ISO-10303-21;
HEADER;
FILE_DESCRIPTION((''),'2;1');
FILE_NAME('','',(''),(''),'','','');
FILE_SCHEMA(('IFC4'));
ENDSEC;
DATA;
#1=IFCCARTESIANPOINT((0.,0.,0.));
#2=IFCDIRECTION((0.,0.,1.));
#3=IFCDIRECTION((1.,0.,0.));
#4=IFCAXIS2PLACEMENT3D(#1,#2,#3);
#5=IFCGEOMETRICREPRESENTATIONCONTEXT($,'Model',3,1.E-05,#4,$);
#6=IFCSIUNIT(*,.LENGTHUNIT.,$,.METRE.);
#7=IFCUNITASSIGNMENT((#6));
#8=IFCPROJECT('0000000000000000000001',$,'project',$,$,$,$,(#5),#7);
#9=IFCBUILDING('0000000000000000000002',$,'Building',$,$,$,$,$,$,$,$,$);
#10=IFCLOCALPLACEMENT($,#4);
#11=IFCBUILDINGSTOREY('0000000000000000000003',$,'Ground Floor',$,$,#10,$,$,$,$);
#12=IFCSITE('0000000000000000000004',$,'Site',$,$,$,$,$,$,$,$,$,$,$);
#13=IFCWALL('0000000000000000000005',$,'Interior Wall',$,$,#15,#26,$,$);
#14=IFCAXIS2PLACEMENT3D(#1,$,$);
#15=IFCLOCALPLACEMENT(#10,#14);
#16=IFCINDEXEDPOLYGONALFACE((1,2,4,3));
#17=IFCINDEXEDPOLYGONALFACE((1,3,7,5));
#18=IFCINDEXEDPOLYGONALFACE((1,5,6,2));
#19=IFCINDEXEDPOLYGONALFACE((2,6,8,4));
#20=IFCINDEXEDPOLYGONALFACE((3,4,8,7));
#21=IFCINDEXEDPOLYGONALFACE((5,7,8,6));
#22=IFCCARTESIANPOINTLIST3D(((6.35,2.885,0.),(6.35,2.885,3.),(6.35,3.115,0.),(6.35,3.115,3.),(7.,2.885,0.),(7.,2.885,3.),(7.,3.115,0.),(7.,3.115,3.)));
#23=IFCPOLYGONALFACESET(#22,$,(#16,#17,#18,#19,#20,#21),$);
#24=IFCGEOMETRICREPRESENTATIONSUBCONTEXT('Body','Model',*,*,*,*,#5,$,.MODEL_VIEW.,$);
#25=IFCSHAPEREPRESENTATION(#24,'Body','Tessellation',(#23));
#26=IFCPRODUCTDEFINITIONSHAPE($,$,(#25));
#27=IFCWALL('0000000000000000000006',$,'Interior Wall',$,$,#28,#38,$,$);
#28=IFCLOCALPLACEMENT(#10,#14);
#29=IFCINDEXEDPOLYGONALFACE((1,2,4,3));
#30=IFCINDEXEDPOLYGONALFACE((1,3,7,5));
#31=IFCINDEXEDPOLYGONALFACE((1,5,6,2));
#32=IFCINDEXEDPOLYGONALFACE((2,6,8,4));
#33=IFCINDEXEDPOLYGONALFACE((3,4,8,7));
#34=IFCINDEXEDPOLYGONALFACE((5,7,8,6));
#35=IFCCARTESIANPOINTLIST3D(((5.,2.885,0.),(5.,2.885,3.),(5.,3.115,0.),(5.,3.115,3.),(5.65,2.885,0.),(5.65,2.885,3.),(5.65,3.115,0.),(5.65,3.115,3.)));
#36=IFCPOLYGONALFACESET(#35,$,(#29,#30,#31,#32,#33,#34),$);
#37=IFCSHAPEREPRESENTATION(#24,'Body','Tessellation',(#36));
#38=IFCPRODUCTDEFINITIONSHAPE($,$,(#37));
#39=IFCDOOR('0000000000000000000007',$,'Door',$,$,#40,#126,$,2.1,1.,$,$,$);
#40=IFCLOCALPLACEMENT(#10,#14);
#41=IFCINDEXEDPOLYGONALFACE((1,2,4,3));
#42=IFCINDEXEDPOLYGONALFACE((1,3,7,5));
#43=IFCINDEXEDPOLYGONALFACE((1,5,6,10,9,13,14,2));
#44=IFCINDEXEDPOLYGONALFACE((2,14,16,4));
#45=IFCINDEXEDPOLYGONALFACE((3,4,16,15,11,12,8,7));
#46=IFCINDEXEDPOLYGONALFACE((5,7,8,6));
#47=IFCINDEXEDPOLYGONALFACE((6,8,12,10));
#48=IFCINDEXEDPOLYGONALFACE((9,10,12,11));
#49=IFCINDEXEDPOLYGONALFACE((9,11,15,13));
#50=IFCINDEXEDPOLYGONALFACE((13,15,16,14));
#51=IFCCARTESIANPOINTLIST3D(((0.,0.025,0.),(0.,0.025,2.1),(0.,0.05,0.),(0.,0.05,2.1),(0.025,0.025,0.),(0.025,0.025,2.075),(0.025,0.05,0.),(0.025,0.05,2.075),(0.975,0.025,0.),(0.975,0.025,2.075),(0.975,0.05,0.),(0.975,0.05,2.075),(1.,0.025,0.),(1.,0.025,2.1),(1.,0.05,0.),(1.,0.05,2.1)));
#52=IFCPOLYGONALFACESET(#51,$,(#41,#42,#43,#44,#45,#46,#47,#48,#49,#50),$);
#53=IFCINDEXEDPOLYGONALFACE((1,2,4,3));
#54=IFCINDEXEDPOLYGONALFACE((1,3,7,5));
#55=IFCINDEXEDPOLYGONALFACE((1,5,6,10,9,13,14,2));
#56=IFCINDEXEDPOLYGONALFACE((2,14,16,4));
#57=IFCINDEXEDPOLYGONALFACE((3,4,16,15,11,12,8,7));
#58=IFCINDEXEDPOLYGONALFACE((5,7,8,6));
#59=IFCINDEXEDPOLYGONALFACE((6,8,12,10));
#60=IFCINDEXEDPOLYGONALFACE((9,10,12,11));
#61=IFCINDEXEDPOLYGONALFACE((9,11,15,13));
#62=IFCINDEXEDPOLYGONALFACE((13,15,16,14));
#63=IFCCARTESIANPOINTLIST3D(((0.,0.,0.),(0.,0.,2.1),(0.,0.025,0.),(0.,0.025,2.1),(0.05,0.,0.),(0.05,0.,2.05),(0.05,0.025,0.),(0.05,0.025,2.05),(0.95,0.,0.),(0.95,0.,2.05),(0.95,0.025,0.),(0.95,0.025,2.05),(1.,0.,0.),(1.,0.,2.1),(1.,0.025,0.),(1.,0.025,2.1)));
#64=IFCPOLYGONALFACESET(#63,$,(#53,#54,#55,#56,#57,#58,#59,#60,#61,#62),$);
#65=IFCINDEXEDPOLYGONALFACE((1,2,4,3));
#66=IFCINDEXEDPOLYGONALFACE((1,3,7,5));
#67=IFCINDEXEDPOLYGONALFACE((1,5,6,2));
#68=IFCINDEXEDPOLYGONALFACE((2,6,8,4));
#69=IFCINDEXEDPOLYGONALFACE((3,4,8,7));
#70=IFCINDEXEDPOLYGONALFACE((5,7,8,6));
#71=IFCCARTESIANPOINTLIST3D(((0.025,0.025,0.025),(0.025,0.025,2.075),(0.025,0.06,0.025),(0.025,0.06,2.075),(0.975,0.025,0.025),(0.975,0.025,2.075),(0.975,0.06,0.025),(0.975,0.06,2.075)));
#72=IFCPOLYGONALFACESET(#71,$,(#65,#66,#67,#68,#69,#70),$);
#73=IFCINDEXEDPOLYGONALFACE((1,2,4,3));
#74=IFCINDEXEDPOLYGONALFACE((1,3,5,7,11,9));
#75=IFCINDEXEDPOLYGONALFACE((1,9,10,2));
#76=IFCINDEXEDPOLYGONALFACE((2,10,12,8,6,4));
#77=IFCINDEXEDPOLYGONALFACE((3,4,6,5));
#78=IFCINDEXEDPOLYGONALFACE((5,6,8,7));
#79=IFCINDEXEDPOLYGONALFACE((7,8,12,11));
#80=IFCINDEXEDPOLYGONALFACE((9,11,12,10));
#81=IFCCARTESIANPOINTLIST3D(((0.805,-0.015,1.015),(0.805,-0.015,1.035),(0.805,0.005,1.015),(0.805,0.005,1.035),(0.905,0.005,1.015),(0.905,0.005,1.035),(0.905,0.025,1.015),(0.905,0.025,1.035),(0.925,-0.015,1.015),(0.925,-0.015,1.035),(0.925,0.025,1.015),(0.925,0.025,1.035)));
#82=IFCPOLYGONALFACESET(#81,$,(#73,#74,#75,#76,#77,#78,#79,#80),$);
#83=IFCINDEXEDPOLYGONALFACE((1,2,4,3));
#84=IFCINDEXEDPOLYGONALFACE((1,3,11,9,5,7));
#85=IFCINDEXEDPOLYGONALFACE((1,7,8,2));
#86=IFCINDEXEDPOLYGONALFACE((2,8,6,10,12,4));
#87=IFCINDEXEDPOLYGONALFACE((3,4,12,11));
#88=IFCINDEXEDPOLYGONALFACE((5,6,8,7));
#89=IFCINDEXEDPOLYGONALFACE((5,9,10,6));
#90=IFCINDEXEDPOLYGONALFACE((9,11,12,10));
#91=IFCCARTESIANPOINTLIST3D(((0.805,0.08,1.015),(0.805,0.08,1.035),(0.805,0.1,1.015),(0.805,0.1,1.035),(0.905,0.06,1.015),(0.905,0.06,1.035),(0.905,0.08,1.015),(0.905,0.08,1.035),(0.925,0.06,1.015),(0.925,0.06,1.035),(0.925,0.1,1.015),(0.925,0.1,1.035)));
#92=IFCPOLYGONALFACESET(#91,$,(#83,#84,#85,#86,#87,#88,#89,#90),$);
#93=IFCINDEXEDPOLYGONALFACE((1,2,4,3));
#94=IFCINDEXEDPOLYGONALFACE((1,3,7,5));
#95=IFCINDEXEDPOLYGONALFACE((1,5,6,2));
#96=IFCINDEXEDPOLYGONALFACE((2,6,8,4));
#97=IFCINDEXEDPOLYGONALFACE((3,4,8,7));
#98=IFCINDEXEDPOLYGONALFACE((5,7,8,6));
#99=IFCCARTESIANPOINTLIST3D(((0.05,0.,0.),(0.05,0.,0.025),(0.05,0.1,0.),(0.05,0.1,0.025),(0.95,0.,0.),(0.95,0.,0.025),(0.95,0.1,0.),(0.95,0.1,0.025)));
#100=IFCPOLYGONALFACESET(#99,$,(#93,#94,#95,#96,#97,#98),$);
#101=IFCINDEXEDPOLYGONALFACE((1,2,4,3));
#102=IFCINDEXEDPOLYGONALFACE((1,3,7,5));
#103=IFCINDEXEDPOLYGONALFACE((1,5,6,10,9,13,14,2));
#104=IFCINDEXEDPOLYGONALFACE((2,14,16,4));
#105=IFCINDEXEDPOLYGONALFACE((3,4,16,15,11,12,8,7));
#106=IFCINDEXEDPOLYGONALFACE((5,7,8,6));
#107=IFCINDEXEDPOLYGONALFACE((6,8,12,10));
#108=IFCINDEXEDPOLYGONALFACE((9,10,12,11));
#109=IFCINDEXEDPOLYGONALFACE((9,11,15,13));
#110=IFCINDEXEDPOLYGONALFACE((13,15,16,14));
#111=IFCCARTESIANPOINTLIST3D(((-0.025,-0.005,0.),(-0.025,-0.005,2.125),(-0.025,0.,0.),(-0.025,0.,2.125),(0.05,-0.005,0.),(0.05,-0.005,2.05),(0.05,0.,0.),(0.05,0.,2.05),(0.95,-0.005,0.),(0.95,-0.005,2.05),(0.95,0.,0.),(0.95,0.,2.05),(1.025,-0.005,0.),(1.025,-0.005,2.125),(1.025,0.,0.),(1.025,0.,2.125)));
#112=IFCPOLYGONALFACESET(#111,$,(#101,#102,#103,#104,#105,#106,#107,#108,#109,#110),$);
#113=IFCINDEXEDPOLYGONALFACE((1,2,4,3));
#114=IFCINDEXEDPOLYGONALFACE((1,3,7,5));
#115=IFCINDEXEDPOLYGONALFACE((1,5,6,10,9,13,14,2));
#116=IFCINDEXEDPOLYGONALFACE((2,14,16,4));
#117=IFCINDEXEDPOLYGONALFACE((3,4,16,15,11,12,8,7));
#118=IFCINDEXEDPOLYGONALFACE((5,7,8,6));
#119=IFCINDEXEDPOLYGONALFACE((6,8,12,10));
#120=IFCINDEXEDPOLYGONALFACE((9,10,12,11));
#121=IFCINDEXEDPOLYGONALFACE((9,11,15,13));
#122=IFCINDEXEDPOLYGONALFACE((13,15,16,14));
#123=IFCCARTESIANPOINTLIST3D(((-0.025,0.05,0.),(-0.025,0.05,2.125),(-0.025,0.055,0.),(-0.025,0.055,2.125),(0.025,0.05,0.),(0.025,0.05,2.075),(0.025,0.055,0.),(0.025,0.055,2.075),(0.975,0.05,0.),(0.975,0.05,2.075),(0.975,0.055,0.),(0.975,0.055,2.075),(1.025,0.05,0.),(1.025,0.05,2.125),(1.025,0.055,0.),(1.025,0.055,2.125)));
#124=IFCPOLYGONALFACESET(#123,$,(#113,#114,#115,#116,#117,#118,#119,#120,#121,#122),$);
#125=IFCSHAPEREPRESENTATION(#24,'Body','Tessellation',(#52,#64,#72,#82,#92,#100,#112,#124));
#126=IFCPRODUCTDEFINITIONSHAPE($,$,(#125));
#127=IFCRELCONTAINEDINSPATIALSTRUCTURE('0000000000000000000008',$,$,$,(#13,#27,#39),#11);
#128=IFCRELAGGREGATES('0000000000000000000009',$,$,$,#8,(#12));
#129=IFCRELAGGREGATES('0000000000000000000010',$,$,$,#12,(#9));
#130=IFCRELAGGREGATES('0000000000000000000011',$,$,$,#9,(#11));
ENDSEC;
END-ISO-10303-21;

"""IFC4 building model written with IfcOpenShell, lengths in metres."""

from ifc_helpers import new_model, si_unit, frame, origin_with_axes, place, context, subcontext, project, spatial, line, indexed_curve, outline, extrude, element, save


model = new_model("IFC4")

# Units and contexts
model_context = context("Model", 3, precision=1e-05, world=origin_with_axes())
body_context = subcontext(model_context, "Body", "Model", "MODEL_VIEW")
ifc_project = project(units=[si_unit("LENGTHUNIT", "METRE")], contexts=[model_context])

# Site, building, storey
site = spatial("IfcSite", under=ifc_project, Name="Site")
building = spatial("IfcBuilding", under=site, Name="Building")
storey_placement = place(None, origin_with_axes())
storey = spatial("IfcBuildingStorey", under=building, at=storey_placement, Name="Ground Floor")

# Walls
for number, where, z_axis, x_axis, name in (
    (1, (7.0, 3.0, 0.0), (0.0, 0.0, 1.0), (-1.0, 0.0, 0.0), "Interior Wall"),
    (2, (5.65, 3.0, 0.0), (0.0, 0.0, 1.0), (-1.0, 0.0, 0.0), "Interior Wall"),
):
    element("IfcWall", number, at=place(storey_placement, frame(where, z_axis=z_axis, x_axis=x_axis)), inside=storey, Name=name, context=body_context, shape_type="SweptSolid", body=[
        extrude(outline(indexed_curve([(0.0, 0.0), (0.0, 0.23), (0.65, 0.23), (0.65, 0.0), (0.0, 0.0)], self_intersect=False)), frame((0.0, -0.115, 0.0), z_axis=(0.0, 0.0, 1.0), x_axis=(1.0, 0.0, 0.0)), (0.0, 0.0, 1.0), 3.0),
    ])

# Door
door_1_placement = place(storey_placement, origin_with_axes())
element("IfcDoor", 3, at=door_1_placement, inside=storey, Name="Door", OverallHeight=2.1, OverallWidth=1.0, context=body_context, shape_type="SweptSolid", body=[
    extrude(outline(indexed_curve([(0.0, 0.0), (0.0, 2.1), (1.0, 2.1), (1.0, 0.0), (0.975, 0.0), (0.975, 2.075), (0.025, 2.075), (0.025, 0.0)], segments=[line(1, 2, 3, 4, 5, 6, 7, 8, 1)])), frame((0.0, 0.025, 0.0), z_axis=(0.0, -1.0, 0.0), x_axis=(1.0, 0.0, 0.0)), (0.0, 0.0, -1.0), 0.025),
    extrude(outline(indexed_curve([(0.0, 0.0), (0.0, 2.1), (1.0, 2.1), (1.0, 0.0), (0.95, 0.0), (0.95, 2.05), (0.05, 2.05), (0.05, 0.0)], segments=[line(1, 2, 3, 4, 5, 6, 7, 8, 1)])), frame((0.0, 0.0, 0.0), z_axis=(0.0, -1.0, 0.0), x_axis=(1.0, 0.0, 0.0)), (0.0, 0.0, -1.0), 0.025),
    extrude(outline(indexed_curve([(0.0, 0.0), (0.95, 0.0), (0.95, 0.035), (0.0, 0.035)], segments=[line(1, 2, 3, 4, 1)])), frame((0.025, 0.025, 0.025), z_axis=(0.0, 0.0, 1.0), x_axis=(1.0, 0.0, 0.0)), (0.0, 0.0, 1.0), 2.05),
    extrude(outline(indexed_curve([(0.0, 0.0), (0.0, -0.04), (-0.12, -0.04), (-0.12, -0.02), (-0.02, -0.02), (-0.02, 0.0)], segments=[line(1, 2, 3, 4, 5, 6, 1)])), frame((0.925, 0.025, 1.015), z_axis=(0.0, 0.0, 1.0), x_axis=(1.0, 0.0, 0.0)), (0.0, 0.0, 1.0), 0.02),
    extrude(outline(indexed_curve([(0.0, 0.0), (0.0, 0.04), (-0.12, 0.04), (-0.12, 0.02), (-0.02, 0.02), (-0.02, 0.0)], segments=[line(1, 2, 3, 4, 5, 6, 1)])), frame((0.925, 0.06, 1.015), z_axis=(0.0, 0.0, 1.0), x_axis=(1.0, 0.0, 0.0)), (0.0, 0.0, 1.0), 0.02),
    extrude(outline(indexed_curve([(0.0, 0.0), (0.9, 0.0), (0.9, 0.1), (0.0, 0.1)], segments=[line(1, 2, 3, 4, 1)])), frame((0.05, 0.0, 0.0), z_axis=(0.0, 0.0, 1.0), x_axis=(1.0, 0.0, 0.0)), (0.0, 0.0, 1.0), 0.025),
    extrude(outline(indexed_curve([(0.0, 0.0), (0.0, 2.125), (1.05, 2.125), (1.05, 0.0), (0.975, 0.0), (0.975, 2.05), (0.075, 2.05), (0.075, 0.0)], segments=[line(1, 2, 3, 4, 5, 6, 7, 8, 1)])), frame((-0.025, -0.005, 0.0), z_axis=(0.0, -1.0, 0.0), x_axis=(1.0, 0.0, 0.0)), (0.0, 0.0, -1.0), 0.005),
    extrude(outline(indexed_curve([(0.0, 0.0), (0.0, 2.125), (1.05, 2.125), (1.05, 0.0), (1.0, 0.0), (1.0, 2.075), (0.05, 2.075), (0.05, 0.0)], segments=[line(1, 2, 3, 4, 5, 6, 7, 8, 1)])), frame((-0.025, 0.05, 0.0), z_axis=(0.0, -1.0, 0.0), x_axis=(1.0, 0.0, 0.0)), (0.0, 0.0, -1.0), 0.005),
])

save(model, "model.ifc")
